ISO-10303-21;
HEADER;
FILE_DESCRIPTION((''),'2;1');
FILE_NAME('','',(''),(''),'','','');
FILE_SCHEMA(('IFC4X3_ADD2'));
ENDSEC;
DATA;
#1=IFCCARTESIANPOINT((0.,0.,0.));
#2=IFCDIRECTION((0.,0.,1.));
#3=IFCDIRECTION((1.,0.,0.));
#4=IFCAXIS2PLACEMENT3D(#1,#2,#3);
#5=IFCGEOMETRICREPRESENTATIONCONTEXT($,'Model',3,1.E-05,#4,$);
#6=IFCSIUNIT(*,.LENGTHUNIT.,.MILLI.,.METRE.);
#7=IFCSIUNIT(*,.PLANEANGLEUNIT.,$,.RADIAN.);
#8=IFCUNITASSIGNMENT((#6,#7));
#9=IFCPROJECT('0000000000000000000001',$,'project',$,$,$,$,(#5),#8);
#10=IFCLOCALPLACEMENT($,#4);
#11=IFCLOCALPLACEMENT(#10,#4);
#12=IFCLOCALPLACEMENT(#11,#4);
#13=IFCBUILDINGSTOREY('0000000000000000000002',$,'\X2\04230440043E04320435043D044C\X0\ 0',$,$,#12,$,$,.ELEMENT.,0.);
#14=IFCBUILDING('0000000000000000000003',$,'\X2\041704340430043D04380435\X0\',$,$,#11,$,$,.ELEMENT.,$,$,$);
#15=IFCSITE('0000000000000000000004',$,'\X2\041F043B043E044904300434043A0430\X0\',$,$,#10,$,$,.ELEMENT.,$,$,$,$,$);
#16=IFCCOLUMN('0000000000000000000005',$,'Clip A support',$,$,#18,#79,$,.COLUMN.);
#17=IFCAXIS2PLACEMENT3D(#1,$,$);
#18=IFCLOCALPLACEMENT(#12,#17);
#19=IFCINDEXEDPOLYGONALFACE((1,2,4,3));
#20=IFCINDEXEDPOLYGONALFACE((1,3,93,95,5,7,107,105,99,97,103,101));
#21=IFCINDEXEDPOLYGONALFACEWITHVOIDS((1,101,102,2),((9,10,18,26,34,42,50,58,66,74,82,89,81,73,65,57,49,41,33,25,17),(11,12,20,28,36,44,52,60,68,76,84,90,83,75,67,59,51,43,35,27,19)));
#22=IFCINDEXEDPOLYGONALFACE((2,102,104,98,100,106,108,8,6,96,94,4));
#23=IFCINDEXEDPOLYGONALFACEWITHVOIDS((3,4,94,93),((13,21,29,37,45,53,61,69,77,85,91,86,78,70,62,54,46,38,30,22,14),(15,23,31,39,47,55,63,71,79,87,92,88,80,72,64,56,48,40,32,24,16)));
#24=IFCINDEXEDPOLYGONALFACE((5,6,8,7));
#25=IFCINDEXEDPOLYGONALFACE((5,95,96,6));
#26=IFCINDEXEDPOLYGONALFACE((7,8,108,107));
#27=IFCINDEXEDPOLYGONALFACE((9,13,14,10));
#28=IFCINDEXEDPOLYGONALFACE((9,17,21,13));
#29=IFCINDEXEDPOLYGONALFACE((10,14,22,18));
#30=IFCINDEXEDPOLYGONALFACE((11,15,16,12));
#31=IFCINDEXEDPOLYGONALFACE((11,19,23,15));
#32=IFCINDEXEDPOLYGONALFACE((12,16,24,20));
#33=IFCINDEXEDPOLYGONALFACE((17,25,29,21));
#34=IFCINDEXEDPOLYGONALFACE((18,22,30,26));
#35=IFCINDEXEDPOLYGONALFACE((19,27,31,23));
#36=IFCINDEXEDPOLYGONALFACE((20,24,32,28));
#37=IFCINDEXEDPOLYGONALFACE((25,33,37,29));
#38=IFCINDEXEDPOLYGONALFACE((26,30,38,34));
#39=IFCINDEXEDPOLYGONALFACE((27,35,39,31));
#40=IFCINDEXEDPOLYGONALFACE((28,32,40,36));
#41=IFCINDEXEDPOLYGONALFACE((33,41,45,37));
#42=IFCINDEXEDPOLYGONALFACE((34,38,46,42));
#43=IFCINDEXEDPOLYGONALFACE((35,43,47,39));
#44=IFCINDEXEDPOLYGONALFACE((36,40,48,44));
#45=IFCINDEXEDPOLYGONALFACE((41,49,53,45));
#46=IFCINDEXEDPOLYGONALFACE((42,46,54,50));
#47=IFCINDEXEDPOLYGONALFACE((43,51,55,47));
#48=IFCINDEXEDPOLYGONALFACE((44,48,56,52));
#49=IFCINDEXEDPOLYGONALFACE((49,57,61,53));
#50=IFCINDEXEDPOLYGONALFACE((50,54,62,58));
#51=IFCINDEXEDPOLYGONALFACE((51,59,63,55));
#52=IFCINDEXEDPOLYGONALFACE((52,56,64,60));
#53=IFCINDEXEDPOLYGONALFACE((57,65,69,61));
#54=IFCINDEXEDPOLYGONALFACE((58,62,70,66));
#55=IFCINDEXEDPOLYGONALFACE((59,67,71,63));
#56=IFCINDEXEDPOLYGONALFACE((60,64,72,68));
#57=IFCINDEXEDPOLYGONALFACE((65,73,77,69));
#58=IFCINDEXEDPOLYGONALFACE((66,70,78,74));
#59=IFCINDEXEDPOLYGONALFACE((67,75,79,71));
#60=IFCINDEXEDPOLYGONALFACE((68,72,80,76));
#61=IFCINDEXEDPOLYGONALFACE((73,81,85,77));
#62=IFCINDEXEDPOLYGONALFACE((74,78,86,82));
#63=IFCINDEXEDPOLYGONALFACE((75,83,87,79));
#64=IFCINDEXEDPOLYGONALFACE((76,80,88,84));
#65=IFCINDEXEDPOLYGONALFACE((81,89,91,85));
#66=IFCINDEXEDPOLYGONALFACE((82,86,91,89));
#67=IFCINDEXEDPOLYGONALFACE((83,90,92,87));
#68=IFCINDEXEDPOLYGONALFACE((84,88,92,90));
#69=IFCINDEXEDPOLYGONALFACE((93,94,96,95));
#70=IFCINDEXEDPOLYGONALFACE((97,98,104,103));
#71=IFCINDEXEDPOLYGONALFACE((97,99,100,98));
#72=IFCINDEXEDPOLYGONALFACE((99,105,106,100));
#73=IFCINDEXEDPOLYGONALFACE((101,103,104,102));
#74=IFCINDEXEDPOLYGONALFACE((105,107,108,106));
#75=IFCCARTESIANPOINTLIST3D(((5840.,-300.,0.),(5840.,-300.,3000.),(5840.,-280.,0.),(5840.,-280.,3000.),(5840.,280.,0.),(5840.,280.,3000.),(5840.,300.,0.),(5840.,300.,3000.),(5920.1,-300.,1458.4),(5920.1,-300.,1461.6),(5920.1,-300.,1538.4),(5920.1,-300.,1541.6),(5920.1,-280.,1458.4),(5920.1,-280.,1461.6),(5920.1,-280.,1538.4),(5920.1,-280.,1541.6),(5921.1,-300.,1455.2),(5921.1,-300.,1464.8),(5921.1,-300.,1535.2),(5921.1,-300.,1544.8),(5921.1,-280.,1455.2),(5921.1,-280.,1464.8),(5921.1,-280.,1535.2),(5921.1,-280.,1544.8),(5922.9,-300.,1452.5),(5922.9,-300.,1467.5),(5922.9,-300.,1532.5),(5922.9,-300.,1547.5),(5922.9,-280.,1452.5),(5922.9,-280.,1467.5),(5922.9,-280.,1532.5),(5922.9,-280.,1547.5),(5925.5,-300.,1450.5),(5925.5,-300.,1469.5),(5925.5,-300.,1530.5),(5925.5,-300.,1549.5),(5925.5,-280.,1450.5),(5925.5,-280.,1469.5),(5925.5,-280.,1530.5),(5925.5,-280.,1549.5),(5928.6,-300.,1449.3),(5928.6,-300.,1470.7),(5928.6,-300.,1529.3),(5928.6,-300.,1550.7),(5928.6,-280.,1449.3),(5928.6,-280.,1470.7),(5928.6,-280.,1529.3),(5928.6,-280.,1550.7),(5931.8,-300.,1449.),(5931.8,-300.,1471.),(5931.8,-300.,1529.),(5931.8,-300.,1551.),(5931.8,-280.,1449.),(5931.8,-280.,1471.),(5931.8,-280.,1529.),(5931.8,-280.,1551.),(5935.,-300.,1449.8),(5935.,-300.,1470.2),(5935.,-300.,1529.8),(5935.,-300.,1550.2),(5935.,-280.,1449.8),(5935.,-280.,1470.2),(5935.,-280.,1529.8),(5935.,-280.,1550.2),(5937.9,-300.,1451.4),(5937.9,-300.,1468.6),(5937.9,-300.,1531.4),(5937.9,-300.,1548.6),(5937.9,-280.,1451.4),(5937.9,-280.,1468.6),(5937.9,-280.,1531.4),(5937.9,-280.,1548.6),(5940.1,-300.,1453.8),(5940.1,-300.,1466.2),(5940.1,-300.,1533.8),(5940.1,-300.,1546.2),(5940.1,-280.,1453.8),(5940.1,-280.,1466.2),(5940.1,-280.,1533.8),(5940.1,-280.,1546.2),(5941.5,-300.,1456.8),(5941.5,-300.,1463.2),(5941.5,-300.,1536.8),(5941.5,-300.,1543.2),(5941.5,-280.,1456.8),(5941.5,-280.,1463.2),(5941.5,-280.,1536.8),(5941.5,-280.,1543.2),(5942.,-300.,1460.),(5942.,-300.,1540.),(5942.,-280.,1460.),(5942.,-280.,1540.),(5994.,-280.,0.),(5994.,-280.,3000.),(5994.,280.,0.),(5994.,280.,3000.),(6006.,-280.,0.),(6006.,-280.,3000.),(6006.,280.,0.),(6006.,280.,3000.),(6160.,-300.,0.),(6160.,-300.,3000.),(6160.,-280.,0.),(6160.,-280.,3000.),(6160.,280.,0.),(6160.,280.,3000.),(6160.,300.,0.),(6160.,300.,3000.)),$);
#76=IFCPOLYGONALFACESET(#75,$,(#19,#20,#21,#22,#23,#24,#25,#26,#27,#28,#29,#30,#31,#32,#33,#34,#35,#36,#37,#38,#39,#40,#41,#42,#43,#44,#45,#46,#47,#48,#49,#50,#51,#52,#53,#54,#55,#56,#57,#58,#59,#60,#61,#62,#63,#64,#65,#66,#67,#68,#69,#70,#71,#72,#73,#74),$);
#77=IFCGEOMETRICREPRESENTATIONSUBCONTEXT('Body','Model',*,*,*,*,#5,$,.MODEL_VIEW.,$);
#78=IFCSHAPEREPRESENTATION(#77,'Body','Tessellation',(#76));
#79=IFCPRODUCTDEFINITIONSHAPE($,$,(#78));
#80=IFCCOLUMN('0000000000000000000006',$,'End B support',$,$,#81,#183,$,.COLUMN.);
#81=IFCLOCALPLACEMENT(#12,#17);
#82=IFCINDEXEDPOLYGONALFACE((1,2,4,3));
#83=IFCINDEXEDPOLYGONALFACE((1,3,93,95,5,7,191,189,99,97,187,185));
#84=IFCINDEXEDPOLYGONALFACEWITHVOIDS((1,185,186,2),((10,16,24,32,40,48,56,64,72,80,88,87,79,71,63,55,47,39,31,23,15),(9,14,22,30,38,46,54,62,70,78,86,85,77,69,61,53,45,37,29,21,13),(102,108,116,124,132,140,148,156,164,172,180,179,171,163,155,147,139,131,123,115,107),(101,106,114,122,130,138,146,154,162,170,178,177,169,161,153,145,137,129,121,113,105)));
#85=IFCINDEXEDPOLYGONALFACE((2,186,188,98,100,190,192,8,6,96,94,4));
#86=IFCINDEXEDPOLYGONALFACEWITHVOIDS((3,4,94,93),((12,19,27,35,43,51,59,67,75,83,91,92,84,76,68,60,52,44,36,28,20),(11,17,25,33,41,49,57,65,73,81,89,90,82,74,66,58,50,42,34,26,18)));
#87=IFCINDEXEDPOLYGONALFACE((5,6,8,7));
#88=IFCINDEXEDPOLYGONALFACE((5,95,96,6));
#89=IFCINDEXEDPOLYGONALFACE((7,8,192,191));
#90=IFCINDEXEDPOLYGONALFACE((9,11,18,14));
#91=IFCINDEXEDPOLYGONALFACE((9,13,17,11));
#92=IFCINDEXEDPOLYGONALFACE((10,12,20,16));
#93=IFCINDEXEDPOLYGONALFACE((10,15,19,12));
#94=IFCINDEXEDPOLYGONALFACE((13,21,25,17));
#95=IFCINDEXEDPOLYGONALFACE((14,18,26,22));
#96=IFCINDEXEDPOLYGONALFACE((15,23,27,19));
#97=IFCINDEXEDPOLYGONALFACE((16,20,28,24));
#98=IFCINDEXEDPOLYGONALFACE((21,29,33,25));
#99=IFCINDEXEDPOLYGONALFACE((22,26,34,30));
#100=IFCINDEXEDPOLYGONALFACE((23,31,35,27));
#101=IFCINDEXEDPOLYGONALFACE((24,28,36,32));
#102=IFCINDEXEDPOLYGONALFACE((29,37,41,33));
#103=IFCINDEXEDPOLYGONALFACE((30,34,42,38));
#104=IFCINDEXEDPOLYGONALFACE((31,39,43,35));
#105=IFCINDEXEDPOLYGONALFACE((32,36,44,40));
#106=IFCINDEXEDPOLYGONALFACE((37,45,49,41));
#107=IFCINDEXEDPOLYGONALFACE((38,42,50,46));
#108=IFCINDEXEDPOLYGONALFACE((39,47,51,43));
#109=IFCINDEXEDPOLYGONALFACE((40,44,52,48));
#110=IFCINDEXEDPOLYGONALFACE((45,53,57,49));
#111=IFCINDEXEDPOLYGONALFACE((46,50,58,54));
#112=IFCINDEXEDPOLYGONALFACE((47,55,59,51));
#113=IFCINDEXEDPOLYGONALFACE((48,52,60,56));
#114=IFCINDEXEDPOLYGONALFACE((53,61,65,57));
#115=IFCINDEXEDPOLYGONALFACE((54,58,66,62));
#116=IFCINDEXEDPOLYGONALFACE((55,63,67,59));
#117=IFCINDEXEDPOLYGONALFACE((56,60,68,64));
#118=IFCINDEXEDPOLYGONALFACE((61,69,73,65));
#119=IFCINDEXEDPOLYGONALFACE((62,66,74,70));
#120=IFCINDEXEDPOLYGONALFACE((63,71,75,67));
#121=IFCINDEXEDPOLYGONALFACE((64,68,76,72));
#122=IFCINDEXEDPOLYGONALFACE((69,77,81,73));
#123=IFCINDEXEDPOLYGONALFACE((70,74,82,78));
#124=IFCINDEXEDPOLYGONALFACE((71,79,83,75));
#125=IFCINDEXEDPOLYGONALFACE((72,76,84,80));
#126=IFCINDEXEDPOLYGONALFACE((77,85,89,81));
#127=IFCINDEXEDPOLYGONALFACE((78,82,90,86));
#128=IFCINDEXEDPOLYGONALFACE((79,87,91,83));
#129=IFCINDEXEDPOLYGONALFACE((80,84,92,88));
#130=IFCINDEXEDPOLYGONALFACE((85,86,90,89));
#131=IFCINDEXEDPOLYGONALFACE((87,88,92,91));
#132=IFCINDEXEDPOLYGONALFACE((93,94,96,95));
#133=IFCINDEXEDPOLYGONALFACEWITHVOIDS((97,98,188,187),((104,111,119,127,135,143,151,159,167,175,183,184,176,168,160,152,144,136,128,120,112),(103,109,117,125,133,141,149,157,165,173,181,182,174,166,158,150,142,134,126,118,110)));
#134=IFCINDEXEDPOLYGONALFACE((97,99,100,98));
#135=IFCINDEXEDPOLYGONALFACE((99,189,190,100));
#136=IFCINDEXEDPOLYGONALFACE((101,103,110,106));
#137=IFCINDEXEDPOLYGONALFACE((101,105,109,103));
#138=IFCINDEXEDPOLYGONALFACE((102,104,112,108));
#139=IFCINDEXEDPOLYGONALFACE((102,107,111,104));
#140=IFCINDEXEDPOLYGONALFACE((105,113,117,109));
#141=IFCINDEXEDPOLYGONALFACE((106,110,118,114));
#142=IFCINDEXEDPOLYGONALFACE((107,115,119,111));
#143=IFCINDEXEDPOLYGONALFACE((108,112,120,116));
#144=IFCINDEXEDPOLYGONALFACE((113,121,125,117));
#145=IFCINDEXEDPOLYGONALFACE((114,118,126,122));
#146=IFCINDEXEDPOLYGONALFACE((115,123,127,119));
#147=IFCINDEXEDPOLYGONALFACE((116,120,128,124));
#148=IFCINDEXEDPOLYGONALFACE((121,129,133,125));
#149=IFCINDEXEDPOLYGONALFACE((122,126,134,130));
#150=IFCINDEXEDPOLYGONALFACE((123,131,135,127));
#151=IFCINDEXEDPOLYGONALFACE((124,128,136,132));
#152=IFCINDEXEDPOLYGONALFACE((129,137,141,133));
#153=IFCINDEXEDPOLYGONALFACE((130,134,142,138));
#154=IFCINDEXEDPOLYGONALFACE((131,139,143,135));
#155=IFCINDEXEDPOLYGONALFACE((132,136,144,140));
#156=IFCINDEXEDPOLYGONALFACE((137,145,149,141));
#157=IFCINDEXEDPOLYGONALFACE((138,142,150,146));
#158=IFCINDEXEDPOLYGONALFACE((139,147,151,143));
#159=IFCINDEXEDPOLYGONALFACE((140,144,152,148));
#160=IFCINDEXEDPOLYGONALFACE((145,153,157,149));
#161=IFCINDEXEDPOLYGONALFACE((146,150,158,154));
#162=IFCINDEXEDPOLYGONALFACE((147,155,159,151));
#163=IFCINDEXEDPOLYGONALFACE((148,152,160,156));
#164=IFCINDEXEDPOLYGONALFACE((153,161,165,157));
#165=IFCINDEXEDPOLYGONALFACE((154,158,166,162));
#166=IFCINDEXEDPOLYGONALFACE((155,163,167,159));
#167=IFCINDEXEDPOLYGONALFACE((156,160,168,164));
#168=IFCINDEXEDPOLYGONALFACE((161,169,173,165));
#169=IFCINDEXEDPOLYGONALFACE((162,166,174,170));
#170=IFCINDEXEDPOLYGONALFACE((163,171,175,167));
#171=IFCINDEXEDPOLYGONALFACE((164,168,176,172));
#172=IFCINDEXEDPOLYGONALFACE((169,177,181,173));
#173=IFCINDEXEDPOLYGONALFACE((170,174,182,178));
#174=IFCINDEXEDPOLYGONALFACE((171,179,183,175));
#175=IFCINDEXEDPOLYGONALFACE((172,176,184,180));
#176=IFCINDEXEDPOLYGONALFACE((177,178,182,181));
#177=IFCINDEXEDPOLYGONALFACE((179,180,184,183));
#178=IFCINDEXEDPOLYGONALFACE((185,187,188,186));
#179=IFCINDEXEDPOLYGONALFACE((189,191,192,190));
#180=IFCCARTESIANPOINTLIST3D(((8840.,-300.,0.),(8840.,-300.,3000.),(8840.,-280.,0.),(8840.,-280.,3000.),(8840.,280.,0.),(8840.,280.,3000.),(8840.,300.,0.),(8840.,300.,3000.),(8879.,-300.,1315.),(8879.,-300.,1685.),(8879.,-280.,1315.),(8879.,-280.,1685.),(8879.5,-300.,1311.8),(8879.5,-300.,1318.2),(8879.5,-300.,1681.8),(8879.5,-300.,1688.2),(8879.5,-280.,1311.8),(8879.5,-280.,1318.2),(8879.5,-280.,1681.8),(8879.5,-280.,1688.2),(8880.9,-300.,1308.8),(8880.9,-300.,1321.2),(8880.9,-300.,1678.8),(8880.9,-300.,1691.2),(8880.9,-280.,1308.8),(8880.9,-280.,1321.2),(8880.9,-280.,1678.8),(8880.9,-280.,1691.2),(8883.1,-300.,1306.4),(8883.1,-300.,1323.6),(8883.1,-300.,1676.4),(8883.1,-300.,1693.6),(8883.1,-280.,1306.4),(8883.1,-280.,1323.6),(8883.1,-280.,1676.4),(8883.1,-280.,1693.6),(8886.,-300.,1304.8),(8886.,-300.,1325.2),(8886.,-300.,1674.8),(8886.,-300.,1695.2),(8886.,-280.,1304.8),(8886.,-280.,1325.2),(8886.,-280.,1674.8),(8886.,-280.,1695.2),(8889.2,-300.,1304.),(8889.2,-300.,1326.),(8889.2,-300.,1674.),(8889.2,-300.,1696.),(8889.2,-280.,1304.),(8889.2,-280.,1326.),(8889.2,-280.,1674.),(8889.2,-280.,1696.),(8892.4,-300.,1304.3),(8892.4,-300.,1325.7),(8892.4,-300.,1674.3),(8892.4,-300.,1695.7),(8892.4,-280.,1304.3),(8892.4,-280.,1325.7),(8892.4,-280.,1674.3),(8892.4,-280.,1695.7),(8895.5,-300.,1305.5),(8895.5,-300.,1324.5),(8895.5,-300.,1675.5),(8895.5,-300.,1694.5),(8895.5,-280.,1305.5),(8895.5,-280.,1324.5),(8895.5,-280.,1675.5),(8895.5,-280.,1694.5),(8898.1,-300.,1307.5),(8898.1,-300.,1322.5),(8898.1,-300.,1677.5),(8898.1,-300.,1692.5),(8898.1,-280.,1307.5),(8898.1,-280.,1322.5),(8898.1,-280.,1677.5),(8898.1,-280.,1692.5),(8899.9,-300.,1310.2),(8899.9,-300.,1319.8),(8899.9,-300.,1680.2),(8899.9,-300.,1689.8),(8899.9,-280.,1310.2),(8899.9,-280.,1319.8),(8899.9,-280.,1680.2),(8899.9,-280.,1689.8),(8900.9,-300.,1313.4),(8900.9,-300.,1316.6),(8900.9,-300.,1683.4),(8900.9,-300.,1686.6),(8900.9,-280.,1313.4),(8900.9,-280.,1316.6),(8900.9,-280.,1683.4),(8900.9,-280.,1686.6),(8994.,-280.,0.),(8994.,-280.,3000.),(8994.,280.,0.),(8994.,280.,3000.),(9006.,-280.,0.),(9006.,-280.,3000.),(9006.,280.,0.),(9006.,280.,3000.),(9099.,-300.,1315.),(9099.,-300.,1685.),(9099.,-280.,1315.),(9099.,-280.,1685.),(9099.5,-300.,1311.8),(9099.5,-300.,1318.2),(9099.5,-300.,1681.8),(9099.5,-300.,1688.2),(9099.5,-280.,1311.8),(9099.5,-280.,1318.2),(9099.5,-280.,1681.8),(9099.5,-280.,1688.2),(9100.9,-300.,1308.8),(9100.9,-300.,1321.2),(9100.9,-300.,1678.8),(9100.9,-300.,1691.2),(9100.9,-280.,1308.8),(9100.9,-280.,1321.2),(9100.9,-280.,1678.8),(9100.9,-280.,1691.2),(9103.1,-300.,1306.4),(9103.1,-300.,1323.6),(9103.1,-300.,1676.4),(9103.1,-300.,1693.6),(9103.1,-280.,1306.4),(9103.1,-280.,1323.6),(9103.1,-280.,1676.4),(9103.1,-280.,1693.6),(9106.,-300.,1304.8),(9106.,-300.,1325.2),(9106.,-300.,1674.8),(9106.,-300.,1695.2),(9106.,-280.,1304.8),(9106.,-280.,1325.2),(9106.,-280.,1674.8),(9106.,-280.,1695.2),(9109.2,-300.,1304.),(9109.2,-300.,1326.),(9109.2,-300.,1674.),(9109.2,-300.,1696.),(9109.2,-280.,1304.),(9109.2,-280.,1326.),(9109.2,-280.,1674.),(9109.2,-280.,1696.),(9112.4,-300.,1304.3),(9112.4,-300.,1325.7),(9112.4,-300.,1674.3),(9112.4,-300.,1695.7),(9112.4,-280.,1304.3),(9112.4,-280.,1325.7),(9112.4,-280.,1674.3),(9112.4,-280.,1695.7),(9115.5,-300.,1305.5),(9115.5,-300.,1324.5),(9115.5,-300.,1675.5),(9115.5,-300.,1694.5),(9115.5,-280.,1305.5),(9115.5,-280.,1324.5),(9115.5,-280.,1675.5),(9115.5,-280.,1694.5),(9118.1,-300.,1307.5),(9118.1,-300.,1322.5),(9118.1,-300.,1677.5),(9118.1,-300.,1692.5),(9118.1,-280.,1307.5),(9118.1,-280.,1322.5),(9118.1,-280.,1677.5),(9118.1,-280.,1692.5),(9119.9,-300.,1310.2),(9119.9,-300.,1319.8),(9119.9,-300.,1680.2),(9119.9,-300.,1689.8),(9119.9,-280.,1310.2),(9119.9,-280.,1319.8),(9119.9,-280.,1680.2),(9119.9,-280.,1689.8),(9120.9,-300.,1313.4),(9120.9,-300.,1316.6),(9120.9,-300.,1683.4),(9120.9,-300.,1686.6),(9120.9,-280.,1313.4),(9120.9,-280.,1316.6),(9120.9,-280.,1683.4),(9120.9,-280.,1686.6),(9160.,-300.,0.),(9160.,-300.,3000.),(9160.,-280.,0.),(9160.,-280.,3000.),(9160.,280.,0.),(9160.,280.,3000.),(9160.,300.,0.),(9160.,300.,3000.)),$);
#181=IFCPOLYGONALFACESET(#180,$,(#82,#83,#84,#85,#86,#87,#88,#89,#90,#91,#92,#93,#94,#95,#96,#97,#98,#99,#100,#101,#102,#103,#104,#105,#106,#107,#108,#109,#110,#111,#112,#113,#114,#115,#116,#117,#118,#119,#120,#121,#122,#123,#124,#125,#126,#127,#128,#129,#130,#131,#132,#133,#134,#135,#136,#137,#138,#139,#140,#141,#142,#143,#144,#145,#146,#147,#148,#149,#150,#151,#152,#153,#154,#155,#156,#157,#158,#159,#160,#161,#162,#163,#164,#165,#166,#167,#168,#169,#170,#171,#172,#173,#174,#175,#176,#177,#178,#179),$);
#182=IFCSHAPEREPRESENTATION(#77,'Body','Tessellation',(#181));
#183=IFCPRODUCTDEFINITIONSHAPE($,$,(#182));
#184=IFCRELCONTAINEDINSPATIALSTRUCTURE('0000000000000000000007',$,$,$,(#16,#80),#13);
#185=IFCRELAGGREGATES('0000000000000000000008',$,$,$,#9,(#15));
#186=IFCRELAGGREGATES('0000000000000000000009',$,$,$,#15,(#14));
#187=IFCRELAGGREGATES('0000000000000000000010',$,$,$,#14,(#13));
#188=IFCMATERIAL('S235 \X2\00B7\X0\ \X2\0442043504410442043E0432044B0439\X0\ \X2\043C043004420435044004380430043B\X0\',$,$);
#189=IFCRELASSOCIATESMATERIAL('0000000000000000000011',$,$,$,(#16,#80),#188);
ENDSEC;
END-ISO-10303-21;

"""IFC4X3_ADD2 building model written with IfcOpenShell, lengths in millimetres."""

from ifc_helpers import new_model, si_unit, frame, origin_with_axes, place, context, subcontext, project, spatial, circle, i_section, extrude, material, element, save


model = new_model("IFC4X3_ADD2")

# Units and contexts
model_context = context("Model", 3, precision=1e-05, world=origin_with_axes())
body_context = subcontext(model_context, "Body", "Model", "MODEL_VIEW")
ifc_project = project(units=[si_unit("LENGTHUNIT", "METRE", prefix="MILLI"), si_unit("PLANEANGLEUNIT", "RADIAN")], contexts=[model_context])

# Site, building, storey
site_placement = place(None, origin_with_axes())
site = spatial("IfcSite", under=ifc_project, at=site_placement, Name="Площадка", CompositionType="ELEMENT")
building_placement = place(site_placement, origin_with_axes())
building = spatial("IfcBuilding", under=site, at=building_placement, Name="Здание", CompositionType="ELEMENT")
storey_placement = place(building_placement, origin_with_axes())
storey = spatial("IfcBuildingStorey", under=building, at=storey_placement, Name="Уровень 0", CompositionType="ELEMENT", Elevation=0.0)

# Columns, openings
ifc_material = material(Name="S235 · тестовый материал")
column_1_placement = place(storey_placement, frame((6000.0, 0.0, 0.0), z_axis=(0.0, 0.0, 1.0), x_axis=(1.0, 0.0, 0.0)))
column_1 = element("IfcColumn", 1, at=column_1_placement, inside=storey, material=ifc_material, Name="Clip A support", PredefinedType="COLUMN", context=body_context, shape_type="SweptSolid", body=[
    extrude(i_section(OverallWidth=320.0, OverallDepth=600.0, WebThickness=12.0, FlangeThickness=20.0), origin_with_axes(), (0.0, 0.0, 1.0), 3000.0),
])
opening_1_placement = place(column_1_placement, frame((-69.0, -321.0, 1540.0), z_axis=(0.0, 1.0, 0.0), x_axis=(1.0, 0.0, 0.0)))
element("IfcOpeningElement", 2, at=opening_1_placement, cuts=column_1, PredefinedType="OPENING", context=body_context, shape_type="SweptSolid", body=[
    extrude(circle(Radius=11.0), origin_with_axes(), (0.0, 0.0, 1.0), 42.0),
])
opening_2_placement = place(column_1_placement, frame((-69.0, -321.0, 1460.0), z_axis=(0.0, 1.0, 0.0), x_axis=(1.0, 0.0, 0.0)))
element("IfcOpeningElement", 3, at=opening_2_placement, cuts=column_1, PredefinedType="OPENING", context=body_context, shape_type="SweptSolid", body=[
    extrude(circle(Radius=11.0), origin_with_axes(), (0.0, 0.0, 1.0), 42.0),
])
column_2_placement = place(storey_placement, frame((9000.0, 0.0, 0.0), z_axis=(0.0, 0.0, 1.0), x_axis=(1.0, 0.0, 0.0)))
column_2 = element("IfcColumn", 4, at=column_2_placement, inside=storey, material=ifc_material, Name="End B support", PredefinedType="COLUMN", context=body_context, shape_type="SweptSolid", body=[
    extrude(i_section(OverallWidth=320.0, OverallDepth=600.0, WebThickness=12.0, FlangeThickness=20.0), origin_with_axes(), (0.0, 0.0, 1.0), 3000.0),
])
opening_3_placement = place(column_2_placement, frame((110.0, -321.0, 1315.0), z_axis=(0.0, 1.0, 0.0), x_axis=(-1.0, 0.0, 0.0)))
element("IfcOpeningElement", 5, at=opening_3_placement, cuts=column_2, PredefinedType="OPENING", context=body_context, shape_type="SweptSolid", body=[
    extrude(circle(Radius=11.0), origin_with_axes(), (0.0, 0.0, 1.0), 42.0),
])
opening_4_placement = place(column_2_placement, frame((110.0, -321.0, 1685.0), z_axis=(0.0, 1.0, 0.0), x_axis=(-1.0, 0.0, 0.0)))
element("IfcOpeningElement", 6, at=opening_4_placement, cuts=column_2, PredefinedType="OPENING", context=body_context, shape_type="SweptSolid", body=[
    extrude(circle(Radius=11.0), origin_with_axes(), (0.0, 0.0, 1.0), 42.0),
])
opening_5_placement = place(column_2_placement, frame((-110.0, -321.0, 1315.0), z_axis=(0.0, 1.0, 0.0), x_axis=(-1.0, 0.0, 0.0)))
element("IfcOpeningElement", 7, at=opening_5_placement, cuts=column_2, PredefinedType="OPENING", context=body_context, shape_type="SweptSolid", body=[
    extrude(circle(Radius=11.0), origin_with_axes(), (0.0, 0.0, 1.0), 42.0),
])
opening_6_placement = place(column_2_placement, frame((-110.0, -321.0, 1685.0), z_axis=(0.0, 1.0, 0.0), x_axis=(-1.0, 0.0, 0.0)))
element("IfcOpeningElement", 8, at=opening_6_placement, cuts=column_2, PredefinedType="OPENING", context=body_context, shape_type="SweptSolid", body=[
    extrude(circle(Radius=11.0), origin_with_axes(), (0.0, 0.0, 1.0), 42.0),
])

save(model, "model.ifc")
